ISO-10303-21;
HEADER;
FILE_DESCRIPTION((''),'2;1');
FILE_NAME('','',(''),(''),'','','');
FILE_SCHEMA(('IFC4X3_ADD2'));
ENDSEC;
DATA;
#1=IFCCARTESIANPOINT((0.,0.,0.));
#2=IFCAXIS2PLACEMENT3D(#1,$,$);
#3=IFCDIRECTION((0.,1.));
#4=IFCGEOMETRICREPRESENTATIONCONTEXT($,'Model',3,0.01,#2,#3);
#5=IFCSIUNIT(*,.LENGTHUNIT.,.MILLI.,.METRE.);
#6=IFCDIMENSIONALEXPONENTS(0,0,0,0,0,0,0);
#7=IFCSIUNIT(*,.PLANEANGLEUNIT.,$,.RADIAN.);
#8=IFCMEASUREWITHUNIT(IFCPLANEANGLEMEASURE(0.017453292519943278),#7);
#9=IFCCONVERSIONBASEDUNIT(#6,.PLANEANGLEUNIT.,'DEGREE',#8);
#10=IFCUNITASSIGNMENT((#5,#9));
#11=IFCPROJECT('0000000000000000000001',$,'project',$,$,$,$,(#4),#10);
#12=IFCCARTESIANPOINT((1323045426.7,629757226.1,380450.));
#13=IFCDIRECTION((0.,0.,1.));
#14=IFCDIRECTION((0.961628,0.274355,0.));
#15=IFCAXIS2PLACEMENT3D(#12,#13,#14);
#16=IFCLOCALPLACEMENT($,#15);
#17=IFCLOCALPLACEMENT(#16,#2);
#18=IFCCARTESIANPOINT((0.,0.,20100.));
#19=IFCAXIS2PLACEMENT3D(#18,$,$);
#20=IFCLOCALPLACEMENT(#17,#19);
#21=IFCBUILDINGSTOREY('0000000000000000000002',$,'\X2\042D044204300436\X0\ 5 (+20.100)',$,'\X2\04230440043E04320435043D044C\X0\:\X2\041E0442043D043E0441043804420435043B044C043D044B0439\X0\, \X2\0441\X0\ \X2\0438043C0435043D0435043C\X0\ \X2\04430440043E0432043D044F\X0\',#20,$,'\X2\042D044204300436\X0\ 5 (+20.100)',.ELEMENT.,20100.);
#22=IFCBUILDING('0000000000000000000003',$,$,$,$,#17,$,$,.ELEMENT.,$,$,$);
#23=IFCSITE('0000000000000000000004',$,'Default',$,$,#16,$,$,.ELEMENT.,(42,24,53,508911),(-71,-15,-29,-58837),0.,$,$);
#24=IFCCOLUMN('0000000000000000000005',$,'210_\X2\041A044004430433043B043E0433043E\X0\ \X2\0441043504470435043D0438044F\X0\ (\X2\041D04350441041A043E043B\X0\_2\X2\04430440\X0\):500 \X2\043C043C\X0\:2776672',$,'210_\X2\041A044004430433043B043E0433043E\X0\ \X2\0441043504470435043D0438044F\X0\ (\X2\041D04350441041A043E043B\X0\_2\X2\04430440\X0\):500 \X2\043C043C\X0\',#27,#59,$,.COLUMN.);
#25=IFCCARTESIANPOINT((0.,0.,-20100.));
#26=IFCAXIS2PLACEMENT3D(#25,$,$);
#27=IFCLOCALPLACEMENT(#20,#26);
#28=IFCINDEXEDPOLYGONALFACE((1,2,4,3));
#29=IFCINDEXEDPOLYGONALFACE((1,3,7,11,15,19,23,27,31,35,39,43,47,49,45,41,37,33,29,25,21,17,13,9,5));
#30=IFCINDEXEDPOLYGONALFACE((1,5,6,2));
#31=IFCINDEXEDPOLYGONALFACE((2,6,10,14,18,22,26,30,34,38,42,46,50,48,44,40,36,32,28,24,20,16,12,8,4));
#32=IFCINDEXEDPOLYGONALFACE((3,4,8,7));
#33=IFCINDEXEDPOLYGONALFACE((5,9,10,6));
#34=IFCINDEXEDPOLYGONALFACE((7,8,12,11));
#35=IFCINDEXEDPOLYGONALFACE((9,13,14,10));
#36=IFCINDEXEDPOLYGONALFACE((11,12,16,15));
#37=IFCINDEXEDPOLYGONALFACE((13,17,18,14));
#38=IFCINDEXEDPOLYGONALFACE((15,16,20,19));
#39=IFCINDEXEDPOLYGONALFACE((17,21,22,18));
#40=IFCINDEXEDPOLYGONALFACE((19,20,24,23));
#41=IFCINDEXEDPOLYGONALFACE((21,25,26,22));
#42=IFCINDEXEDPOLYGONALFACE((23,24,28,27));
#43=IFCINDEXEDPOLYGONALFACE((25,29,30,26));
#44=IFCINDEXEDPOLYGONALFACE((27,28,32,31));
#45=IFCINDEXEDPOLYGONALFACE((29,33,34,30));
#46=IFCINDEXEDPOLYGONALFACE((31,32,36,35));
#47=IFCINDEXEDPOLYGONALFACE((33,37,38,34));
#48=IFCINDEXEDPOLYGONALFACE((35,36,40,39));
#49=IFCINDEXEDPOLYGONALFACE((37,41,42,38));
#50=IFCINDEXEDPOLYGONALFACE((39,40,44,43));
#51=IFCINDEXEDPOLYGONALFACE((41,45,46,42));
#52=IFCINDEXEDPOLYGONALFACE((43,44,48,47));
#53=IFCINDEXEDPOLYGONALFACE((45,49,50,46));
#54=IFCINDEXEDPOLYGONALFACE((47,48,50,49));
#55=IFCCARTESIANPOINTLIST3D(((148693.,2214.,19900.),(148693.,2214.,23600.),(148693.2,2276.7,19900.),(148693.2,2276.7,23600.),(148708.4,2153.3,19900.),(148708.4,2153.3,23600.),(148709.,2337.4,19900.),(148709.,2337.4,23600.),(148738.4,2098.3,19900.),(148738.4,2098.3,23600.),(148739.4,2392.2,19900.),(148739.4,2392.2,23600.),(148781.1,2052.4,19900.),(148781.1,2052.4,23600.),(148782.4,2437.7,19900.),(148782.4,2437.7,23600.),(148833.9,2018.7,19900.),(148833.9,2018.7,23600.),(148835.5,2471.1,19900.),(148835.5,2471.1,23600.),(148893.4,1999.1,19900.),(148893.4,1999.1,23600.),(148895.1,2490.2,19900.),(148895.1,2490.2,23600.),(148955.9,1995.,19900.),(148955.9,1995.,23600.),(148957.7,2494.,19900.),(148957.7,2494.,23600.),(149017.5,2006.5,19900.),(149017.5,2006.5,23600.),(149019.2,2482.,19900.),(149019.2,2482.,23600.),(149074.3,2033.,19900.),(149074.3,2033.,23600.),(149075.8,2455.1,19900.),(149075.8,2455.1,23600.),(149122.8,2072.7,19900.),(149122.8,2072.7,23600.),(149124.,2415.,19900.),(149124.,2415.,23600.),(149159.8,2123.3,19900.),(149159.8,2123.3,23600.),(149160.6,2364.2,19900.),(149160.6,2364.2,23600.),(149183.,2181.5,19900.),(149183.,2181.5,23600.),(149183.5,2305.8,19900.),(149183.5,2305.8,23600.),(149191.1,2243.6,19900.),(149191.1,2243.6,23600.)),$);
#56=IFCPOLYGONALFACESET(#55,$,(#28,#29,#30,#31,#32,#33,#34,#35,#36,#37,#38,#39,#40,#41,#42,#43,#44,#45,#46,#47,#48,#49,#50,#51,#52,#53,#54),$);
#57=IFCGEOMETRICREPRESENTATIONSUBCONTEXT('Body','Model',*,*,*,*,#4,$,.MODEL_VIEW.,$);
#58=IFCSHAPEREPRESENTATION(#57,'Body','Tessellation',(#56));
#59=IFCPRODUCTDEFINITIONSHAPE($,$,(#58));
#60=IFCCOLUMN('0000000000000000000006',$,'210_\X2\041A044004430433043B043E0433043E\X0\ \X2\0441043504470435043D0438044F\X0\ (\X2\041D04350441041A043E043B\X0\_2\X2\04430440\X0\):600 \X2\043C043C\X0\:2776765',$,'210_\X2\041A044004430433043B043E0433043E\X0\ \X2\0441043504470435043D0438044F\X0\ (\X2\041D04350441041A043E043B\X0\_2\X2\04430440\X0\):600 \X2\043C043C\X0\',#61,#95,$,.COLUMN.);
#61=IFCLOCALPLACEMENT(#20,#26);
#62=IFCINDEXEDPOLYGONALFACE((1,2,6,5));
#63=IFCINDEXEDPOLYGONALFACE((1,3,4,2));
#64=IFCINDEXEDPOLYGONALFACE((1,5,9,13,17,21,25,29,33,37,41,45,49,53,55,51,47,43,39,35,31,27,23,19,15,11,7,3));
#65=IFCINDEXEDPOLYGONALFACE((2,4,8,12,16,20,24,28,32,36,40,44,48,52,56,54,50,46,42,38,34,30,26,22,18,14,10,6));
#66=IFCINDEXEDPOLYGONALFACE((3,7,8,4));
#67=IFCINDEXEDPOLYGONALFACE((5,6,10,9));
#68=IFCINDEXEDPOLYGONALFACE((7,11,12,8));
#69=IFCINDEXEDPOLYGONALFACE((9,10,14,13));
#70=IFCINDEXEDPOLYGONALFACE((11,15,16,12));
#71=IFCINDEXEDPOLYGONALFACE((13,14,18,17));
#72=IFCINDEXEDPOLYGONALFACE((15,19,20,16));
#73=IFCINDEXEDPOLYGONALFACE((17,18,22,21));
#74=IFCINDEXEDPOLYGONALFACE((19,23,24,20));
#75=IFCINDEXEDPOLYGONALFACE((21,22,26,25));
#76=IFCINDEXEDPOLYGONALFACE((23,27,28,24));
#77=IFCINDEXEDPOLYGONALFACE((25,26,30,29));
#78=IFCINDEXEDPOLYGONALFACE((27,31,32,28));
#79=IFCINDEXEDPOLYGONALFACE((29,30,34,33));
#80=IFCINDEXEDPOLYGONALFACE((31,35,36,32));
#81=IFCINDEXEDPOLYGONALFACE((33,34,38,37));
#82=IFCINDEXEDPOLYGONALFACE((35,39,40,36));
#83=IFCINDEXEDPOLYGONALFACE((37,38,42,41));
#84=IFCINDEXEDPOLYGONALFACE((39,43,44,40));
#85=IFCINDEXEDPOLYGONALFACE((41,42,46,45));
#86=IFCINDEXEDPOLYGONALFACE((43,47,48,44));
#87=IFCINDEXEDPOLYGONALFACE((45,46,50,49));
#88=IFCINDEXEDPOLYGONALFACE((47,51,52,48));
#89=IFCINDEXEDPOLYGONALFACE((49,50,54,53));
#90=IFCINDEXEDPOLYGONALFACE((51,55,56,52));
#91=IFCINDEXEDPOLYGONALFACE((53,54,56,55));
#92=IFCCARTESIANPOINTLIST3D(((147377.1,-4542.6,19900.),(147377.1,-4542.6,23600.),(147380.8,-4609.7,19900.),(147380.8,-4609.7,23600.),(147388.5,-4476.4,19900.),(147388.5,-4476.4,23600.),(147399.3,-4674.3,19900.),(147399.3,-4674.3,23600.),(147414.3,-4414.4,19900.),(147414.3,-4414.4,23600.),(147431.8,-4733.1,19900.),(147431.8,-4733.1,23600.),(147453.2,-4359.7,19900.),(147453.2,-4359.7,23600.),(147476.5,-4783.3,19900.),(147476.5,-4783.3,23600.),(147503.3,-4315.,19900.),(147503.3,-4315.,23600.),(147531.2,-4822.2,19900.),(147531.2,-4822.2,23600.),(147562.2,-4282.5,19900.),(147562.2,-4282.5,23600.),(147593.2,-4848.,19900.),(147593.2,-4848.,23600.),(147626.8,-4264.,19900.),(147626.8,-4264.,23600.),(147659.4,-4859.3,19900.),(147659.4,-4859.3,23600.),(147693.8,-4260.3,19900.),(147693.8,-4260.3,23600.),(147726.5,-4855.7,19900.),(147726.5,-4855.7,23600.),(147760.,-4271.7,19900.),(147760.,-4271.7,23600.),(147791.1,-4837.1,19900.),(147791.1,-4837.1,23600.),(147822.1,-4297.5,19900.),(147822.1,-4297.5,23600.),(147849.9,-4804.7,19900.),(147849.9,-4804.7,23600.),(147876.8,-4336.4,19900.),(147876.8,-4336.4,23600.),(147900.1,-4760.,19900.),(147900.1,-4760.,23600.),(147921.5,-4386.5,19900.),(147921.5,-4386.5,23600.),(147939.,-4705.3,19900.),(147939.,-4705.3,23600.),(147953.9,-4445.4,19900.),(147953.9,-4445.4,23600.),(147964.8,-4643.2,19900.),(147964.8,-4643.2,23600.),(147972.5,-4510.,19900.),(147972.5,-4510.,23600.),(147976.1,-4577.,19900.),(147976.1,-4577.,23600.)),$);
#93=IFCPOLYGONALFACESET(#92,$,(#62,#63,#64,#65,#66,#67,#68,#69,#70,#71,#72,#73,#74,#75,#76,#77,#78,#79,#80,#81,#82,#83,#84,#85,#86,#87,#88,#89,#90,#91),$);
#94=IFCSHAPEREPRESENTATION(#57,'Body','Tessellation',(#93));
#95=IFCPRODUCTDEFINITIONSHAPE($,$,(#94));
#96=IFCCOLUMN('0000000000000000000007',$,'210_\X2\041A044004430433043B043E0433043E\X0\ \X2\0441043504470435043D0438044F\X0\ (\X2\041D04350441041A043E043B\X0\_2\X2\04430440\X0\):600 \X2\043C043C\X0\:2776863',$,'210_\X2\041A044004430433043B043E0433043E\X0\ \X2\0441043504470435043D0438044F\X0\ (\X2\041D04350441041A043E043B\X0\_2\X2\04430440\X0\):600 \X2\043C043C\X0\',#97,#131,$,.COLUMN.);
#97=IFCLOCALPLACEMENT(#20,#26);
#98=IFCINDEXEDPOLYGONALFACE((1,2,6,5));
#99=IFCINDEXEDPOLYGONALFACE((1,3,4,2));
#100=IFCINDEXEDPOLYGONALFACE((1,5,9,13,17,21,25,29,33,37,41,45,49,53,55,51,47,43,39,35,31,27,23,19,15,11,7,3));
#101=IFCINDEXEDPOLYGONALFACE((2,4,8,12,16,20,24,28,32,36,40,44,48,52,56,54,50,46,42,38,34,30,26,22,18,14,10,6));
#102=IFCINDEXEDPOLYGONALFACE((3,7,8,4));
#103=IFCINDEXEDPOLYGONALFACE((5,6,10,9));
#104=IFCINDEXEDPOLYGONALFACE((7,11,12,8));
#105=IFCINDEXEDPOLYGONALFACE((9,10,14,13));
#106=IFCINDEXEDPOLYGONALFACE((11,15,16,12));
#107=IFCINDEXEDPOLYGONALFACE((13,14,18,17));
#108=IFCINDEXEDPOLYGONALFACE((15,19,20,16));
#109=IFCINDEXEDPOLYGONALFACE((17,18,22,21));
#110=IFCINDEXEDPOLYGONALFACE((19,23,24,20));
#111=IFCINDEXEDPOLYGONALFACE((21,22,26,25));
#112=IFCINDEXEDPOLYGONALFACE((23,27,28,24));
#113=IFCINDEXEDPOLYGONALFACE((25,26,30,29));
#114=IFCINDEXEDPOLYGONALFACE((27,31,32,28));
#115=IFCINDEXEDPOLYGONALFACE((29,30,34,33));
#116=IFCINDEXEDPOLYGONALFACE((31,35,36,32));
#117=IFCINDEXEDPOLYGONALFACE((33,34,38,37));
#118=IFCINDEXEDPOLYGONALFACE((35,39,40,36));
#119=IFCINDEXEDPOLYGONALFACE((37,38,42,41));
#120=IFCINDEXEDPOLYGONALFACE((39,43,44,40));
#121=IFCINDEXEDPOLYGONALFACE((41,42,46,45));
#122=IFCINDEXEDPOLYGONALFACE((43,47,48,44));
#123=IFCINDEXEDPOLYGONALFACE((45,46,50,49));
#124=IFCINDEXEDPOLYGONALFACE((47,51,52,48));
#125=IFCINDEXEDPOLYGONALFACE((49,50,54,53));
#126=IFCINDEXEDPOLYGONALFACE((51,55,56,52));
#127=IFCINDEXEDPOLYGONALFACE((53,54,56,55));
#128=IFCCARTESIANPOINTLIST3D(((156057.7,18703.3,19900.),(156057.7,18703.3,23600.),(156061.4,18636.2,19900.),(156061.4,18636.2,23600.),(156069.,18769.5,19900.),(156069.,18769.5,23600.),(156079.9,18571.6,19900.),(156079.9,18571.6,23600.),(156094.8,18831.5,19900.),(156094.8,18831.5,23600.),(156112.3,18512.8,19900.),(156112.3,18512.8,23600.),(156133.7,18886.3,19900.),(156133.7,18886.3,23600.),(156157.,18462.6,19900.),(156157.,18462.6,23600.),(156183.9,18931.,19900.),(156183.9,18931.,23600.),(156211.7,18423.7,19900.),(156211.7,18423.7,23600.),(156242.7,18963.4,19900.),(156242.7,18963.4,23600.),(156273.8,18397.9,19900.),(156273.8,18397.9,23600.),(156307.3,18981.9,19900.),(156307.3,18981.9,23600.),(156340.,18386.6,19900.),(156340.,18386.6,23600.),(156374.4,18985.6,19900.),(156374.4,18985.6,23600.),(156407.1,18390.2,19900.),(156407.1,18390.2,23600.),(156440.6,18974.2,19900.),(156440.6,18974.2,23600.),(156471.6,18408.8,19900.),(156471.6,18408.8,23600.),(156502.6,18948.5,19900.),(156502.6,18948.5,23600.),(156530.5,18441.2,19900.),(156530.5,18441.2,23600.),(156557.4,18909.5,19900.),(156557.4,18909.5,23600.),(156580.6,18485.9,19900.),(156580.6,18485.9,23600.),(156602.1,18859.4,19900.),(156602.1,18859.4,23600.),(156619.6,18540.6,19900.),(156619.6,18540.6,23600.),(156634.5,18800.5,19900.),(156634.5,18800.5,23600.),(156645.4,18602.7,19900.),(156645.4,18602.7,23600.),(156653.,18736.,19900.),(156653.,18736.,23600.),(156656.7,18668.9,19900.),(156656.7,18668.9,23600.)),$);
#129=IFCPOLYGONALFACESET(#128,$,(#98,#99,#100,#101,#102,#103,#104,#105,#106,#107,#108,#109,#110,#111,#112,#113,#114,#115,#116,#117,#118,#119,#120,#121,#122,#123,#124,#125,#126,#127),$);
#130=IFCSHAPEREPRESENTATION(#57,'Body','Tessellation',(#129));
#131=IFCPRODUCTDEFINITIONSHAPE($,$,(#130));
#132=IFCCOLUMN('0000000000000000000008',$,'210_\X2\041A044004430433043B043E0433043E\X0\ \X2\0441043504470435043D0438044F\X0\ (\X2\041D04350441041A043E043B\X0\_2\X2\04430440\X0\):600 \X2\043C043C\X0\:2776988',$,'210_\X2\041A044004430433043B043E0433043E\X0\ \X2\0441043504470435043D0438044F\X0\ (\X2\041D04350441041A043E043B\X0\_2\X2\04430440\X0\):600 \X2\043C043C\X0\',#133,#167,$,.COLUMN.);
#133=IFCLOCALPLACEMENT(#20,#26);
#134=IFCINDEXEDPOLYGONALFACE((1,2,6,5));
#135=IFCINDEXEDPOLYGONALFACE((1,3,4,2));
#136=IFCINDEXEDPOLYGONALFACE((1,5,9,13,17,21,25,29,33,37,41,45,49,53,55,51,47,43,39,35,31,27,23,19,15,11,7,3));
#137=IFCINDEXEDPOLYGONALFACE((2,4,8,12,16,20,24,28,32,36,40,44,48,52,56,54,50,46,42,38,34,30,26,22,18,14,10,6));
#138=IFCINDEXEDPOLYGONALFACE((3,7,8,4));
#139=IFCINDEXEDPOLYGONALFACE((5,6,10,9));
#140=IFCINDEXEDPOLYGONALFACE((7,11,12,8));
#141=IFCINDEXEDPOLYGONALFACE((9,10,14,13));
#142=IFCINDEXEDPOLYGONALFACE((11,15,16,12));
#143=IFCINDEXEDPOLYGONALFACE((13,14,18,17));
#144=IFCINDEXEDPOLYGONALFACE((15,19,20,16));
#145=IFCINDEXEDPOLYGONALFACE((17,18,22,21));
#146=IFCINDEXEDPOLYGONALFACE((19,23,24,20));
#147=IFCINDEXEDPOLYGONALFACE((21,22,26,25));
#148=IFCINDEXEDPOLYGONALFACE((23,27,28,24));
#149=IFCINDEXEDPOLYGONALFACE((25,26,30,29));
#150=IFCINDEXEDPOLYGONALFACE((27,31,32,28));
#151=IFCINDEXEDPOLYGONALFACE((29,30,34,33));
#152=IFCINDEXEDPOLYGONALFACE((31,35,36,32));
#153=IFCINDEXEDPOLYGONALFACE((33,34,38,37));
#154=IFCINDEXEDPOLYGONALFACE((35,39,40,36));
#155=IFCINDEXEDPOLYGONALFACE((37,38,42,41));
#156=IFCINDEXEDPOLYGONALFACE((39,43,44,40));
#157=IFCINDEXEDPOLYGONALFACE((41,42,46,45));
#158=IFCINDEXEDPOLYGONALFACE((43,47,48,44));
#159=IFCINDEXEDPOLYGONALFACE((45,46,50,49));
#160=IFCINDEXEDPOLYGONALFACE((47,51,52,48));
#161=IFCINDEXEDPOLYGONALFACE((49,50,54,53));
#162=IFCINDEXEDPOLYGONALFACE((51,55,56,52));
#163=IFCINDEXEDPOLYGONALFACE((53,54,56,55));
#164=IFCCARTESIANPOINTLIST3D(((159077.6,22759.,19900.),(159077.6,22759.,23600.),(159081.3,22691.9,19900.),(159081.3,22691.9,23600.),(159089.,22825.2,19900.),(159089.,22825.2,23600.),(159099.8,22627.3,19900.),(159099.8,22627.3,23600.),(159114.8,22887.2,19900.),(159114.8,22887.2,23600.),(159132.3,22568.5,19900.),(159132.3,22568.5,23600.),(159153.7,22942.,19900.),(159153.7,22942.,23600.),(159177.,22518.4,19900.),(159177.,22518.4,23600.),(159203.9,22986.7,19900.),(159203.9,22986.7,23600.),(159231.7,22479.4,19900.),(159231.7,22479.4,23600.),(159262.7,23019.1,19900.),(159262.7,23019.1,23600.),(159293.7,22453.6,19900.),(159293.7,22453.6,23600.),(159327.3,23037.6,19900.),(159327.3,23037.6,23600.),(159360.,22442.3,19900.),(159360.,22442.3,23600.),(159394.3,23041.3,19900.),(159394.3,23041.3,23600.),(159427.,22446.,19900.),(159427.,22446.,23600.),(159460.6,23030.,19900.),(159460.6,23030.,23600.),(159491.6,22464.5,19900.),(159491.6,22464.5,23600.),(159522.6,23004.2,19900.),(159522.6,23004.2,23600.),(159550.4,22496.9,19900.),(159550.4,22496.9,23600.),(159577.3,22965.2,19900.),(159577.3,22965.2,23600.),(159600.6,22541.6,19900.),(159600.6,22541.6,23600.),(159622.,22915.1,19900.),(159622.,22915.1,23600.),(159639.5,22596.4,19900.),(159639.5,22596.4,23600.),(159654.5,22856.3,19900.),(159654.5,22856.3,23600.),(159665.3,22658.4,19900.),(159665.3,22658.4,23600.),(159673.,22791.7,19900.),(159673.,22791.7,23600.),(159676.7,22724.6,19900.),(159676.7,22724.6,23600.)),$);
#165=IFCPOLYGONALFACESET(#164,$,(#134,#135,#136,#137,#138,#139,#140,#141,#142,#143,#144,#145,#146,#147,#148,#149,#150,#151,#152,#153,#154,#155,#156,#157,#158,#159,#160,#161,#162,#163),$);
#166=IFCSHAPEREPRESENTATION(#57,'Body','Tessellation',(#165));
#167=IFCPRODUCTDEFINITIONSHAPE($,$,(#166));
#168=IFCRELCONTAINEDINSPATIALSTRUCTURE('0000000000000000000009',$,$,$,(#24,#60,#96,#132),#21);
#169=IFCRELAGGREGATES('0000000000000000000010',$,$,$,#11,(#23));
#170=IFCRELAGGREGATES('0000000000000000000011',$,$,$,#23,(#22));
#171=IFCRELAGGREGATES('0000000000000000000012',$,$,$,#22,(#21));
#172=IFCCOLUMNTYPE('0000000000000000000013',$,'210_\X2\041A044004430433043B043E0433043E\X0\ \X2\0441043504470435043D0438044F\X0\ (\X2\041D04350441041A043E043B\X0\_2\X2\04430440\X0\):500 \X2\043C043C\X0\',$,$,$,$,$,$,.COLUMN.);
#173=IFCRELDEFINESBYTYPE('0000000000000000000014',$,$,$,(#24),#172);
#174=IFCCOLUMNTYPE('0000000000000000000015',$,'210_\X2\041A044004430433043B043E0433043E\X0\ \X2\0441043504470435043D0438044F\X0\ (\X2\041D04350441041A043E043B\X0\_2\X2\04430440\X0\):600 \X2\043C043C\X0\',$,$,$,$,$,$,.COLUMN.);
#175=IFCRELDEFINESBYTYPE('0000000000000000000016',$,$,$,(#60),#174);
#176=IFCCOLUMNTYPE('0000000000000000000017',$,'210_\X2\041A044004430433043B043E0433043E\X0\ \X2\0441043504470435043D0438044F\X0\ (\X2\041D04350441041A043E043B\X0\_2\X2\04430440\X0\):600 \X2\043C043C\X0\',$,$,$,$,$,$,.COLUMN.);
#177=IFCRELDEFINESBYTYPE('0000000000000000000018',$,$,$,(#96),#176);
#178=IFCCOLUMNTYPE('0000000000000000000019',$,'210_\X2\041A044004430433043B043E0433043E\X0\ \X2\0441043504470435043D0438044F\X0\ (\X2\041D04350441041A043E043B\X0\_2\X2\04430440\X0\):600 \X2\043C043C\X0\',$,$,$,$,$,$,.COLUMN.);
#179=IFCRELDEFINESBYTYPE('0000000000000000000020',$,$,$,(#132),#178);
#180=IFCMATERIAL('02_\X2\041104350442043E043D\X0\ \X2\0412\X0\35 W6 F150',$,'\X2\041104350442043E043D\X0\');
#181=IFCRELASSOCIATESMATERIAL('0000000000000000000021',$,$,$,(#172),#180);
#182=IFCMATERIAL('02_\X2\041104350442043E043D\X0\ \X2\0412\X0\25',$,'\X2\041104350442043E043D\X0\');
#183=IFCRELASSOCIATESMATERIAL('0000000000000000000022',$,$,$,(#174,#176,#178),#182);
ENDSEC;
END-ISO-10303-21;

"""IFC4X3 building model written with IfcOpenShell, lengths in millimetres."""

from ifc_helpers import new_model, entity, si_unit, converted_unit, direction, frame, frame_2d, origin, place, context, subcontext, project, spatial, circle, extrude, source, transform, mapped, material, material_profile, profile_set, type_object, type_shapes, element, save


model = new_model("IFC4X3")

# Units and contexts
model_context = context("Model", 3, precision=0.01, world=origin(), true_north=direction((0.0, 1.0)))
body_context = subcontext(model_context, "Body", "Model", "MODEL_VIEW")
ifc_project = project(units=[si_unit("LENGTHUNIT", "METRE", prefix="MILLI"), converted_unit("PLANEANGLEUNIT", "DEGREE", entity("IfcPlaneAngleMeasure", 0.017453292519943278), si_unit("PLANEANGLEUNIT", "RADIAN"), dimensions=[0, 0, 0, 0, 0, 0, 0])], contexts=[model_context])

# Site, building, storey
site_placement = place(None, frame((1323045426.7, 629757226.1, 380450.0), z_axis=(0.0, 0.0, 1.0), x_axis=(0.961628, 0.274355, 0.0)))
site = spatial("IfcSite", under=ifc_project, at=site_placement, Name="Default", CompositionType="ELEMENT", RefLatitude=(42, 24, 53, 508911), RefLongitude=(-71, -15, -29, -58837), RefElevation=0.0)
building_placement = place(site_placement, origin())
building = spatial("IfcBuilding", under=site, at=building_placement, CompositionType="ELEMENT")
storey_placement = place(building_placement, frame((0.0, 0.0, 20100.0)))
storey = spatial("IfcBuildingStorey", under=building, at=storey_placement, Name="Этаж 5 (+20.100)", ObjectType="Уровень:Относительный, с именем уровня", LongName="Этаж 5 (+20.100)", CompositionType="ELEMENT", Elevation=20100.0)

# Columns
ifc_material_1 = material(Name="02_Бетон В35 W6 F150", Category="Бетон")
ifc_material_profile_1 = material_profile(ifc_material_1, circle(Radius=250.0, at=frame_2d((0.0, 0.0), x_axis=(1.0, 0.0))), Name="500 мм")
ifc_profile_set_1 = profile_set([ifc_material_profile_1], Name="500 мм")
ifc_material_2 = material(Name="02_Бетон В25", Category="Бетон")
ifc_material_profile_2 = material_profile(ifc_material_2, circle(Radius=300.0, at=frame_2d((0.0, 0.0), x_axis=(1.0, 0.0))), Name="600 мм")
ifc_profile_set_2 = profile_set([ifc_material_profile_2], Name="600 мм")
column_type_1 = type_object("IfcColumnType", Name="210_Круглого сечения (НесКол_2ур):500 мм", PredefinedType="COLUMN", material=ifc_profile_set_1)
shared_shape_1 = source(origin(), body_context, "Body", "SweptSolid", [
    extrude(circle(Radius=250.0, at=frame_2d((0.0, 0.0), x_axis=(1.0, 0.0))), frame((148941.1, 2244.5, 19900.0), z_axis=(0.0, 0.0, 1.0), x_axis=(0.87462, -0.48481, 0.0)), (0.0, 0.0, 1.0), 3700.0),
])
type_shapes(column_type_1, [shared_shape_1])
column_1_placement = place(storey_placement, frame((0.0, 0.0, -20100.0)))
element("IfcColumn", 1, at=column_1_placement, inside=storey, type_object=column_type_1, Name="210_Круглого сечения (НесКол_2ур):500 мм:2776672", ObjectType="210_Круглого сечения (НесКол_2ур):500 мм", PredefinedType="COLUMN", context=body_context, shape_type="MappedRepresentation", body=[
    mapped(shared_shape_1, transform((0.0, 0.0, 0.0), scale=1.0)),
])
column_type_2 = type_object("IfcColumnType", Name="210_Круглого сечения (НесКол_2ур):600 мм", PredefinedType="COLUMN", material=ifc_profile_set_2)
shared_shape_2 = source(origin(), body_context, "Body", "SweptSolid", [
    extrude(circle(Radius=300.0, at=frame_2d((0.0, 0.0), x_axis=(1.0, 0.0))), frame((147676.6, -4559.8, 19900.0), z_axis=(0.0, 0.0, 1.0), x_axis=(0.87462, -0.48481, 0.0)), (0.0, 0.0, 1.0), 3700.0),
])
type_shapes(column_type_2, [shared_shape_2])
column_2_placement = place(storey_placement, frame((0.0, 0.0, -20100.0)))
element("IfcColumn", 2, at=column_2_placement, inside=storey, type_object=column_type_2, Name="210_Круглого сечения (НесКол_2ур):600 мм:2776765", ObjectType="210_Круглого сечения (НесКол_2ур):600 мм", PredefinedType="COLUMN", context=body_context, shape_type="MappedRepresentation", body=[
    mapped(shared_shape_2, transform((0.0, 0.0, 0.0), scale=1.0)),
])
column_type_3 = type_object("IfcColumnType", Name="210_Круглого сечения (НесКол_2ур):600 мм", PredefinedType="COLUMN", material=ifc_profile_set_2)
shared_shape_3 = source(origin(), body_context, "Body", "SweptSolid", [
    extrude(circle(Radius=300.0, at=frame_2d((0.0, 0.0), x_axis=(1.0, 0.0))), frame((156357.2, 18686.1, 19900.0), z_axis=(0.0, 0.0, 1.0), x_axis=(0.87462, -0.48481, 0.0)), (0.0, 0.0, 1.0), 3700.0),
])
type_shapes(column_type_3, [shared_shape_3])
column_3_placement = place(storey_placement, frame((0.0, 0.0, -20100.0)))
element("IfcColumn", 3, at=column_3_placement, inside=storey, type_object=column_type_3, Name="210_Круглого сечения (НесКол_2ур):600 мм:2776863", ObjectType="210_Круглого сечения (НесКол_2ур):600 мм", PredefinedType="COLUMN", context=body_context, shape_type="MappedRepresentation", body=[
    mapped(shared_shape_3, transform((0.0, 0.0, 0.0), scale=1.0)),
])
column_type_4 = type_object("IfcColumnType", Name="210_Круглого сечения (НесКол_2ур):600 мм", PredefinedType="COLUMN", material=ifc_profile_set_2)
shared_shape_4 = source(origin(), body_context, "Body", "SweptSolid", [
    extrude(circle(Radius=300.0, at=frame_2d((0.0, 0.0), x_axis=(1.0, 0.0))), frame((159377.1, 22741.8, 19900.0), z_axis=(0.0, 0.0, 1.0), x_axis=(0.87462, -0.48481, 0.0)), (0.0, 0.0, 1.0), 3700.0),
])
type_shapes(column_type_4, [shared_shape_4])
column_4_placement = place(storey_placement, frame((0.0, 0.0, -20100.0)))
element("IfcColumn", 4, at=column_4_placement, inside=storey, type_object=column_type_4, Name="210_Круглого сечения (НесКол_2ур):600 мм:2776988", ObjectType="210_Круглого сечения (НесКол_2ур):600 мм", PredefinedType="COLUMN", context=body_context, shape_type="MappedRepresentation", body=[
    mapped(shared_shape_4, transform((0.0, 0.0, 0.0), scale=1.0)),
])

save(model, "model.ifc")
